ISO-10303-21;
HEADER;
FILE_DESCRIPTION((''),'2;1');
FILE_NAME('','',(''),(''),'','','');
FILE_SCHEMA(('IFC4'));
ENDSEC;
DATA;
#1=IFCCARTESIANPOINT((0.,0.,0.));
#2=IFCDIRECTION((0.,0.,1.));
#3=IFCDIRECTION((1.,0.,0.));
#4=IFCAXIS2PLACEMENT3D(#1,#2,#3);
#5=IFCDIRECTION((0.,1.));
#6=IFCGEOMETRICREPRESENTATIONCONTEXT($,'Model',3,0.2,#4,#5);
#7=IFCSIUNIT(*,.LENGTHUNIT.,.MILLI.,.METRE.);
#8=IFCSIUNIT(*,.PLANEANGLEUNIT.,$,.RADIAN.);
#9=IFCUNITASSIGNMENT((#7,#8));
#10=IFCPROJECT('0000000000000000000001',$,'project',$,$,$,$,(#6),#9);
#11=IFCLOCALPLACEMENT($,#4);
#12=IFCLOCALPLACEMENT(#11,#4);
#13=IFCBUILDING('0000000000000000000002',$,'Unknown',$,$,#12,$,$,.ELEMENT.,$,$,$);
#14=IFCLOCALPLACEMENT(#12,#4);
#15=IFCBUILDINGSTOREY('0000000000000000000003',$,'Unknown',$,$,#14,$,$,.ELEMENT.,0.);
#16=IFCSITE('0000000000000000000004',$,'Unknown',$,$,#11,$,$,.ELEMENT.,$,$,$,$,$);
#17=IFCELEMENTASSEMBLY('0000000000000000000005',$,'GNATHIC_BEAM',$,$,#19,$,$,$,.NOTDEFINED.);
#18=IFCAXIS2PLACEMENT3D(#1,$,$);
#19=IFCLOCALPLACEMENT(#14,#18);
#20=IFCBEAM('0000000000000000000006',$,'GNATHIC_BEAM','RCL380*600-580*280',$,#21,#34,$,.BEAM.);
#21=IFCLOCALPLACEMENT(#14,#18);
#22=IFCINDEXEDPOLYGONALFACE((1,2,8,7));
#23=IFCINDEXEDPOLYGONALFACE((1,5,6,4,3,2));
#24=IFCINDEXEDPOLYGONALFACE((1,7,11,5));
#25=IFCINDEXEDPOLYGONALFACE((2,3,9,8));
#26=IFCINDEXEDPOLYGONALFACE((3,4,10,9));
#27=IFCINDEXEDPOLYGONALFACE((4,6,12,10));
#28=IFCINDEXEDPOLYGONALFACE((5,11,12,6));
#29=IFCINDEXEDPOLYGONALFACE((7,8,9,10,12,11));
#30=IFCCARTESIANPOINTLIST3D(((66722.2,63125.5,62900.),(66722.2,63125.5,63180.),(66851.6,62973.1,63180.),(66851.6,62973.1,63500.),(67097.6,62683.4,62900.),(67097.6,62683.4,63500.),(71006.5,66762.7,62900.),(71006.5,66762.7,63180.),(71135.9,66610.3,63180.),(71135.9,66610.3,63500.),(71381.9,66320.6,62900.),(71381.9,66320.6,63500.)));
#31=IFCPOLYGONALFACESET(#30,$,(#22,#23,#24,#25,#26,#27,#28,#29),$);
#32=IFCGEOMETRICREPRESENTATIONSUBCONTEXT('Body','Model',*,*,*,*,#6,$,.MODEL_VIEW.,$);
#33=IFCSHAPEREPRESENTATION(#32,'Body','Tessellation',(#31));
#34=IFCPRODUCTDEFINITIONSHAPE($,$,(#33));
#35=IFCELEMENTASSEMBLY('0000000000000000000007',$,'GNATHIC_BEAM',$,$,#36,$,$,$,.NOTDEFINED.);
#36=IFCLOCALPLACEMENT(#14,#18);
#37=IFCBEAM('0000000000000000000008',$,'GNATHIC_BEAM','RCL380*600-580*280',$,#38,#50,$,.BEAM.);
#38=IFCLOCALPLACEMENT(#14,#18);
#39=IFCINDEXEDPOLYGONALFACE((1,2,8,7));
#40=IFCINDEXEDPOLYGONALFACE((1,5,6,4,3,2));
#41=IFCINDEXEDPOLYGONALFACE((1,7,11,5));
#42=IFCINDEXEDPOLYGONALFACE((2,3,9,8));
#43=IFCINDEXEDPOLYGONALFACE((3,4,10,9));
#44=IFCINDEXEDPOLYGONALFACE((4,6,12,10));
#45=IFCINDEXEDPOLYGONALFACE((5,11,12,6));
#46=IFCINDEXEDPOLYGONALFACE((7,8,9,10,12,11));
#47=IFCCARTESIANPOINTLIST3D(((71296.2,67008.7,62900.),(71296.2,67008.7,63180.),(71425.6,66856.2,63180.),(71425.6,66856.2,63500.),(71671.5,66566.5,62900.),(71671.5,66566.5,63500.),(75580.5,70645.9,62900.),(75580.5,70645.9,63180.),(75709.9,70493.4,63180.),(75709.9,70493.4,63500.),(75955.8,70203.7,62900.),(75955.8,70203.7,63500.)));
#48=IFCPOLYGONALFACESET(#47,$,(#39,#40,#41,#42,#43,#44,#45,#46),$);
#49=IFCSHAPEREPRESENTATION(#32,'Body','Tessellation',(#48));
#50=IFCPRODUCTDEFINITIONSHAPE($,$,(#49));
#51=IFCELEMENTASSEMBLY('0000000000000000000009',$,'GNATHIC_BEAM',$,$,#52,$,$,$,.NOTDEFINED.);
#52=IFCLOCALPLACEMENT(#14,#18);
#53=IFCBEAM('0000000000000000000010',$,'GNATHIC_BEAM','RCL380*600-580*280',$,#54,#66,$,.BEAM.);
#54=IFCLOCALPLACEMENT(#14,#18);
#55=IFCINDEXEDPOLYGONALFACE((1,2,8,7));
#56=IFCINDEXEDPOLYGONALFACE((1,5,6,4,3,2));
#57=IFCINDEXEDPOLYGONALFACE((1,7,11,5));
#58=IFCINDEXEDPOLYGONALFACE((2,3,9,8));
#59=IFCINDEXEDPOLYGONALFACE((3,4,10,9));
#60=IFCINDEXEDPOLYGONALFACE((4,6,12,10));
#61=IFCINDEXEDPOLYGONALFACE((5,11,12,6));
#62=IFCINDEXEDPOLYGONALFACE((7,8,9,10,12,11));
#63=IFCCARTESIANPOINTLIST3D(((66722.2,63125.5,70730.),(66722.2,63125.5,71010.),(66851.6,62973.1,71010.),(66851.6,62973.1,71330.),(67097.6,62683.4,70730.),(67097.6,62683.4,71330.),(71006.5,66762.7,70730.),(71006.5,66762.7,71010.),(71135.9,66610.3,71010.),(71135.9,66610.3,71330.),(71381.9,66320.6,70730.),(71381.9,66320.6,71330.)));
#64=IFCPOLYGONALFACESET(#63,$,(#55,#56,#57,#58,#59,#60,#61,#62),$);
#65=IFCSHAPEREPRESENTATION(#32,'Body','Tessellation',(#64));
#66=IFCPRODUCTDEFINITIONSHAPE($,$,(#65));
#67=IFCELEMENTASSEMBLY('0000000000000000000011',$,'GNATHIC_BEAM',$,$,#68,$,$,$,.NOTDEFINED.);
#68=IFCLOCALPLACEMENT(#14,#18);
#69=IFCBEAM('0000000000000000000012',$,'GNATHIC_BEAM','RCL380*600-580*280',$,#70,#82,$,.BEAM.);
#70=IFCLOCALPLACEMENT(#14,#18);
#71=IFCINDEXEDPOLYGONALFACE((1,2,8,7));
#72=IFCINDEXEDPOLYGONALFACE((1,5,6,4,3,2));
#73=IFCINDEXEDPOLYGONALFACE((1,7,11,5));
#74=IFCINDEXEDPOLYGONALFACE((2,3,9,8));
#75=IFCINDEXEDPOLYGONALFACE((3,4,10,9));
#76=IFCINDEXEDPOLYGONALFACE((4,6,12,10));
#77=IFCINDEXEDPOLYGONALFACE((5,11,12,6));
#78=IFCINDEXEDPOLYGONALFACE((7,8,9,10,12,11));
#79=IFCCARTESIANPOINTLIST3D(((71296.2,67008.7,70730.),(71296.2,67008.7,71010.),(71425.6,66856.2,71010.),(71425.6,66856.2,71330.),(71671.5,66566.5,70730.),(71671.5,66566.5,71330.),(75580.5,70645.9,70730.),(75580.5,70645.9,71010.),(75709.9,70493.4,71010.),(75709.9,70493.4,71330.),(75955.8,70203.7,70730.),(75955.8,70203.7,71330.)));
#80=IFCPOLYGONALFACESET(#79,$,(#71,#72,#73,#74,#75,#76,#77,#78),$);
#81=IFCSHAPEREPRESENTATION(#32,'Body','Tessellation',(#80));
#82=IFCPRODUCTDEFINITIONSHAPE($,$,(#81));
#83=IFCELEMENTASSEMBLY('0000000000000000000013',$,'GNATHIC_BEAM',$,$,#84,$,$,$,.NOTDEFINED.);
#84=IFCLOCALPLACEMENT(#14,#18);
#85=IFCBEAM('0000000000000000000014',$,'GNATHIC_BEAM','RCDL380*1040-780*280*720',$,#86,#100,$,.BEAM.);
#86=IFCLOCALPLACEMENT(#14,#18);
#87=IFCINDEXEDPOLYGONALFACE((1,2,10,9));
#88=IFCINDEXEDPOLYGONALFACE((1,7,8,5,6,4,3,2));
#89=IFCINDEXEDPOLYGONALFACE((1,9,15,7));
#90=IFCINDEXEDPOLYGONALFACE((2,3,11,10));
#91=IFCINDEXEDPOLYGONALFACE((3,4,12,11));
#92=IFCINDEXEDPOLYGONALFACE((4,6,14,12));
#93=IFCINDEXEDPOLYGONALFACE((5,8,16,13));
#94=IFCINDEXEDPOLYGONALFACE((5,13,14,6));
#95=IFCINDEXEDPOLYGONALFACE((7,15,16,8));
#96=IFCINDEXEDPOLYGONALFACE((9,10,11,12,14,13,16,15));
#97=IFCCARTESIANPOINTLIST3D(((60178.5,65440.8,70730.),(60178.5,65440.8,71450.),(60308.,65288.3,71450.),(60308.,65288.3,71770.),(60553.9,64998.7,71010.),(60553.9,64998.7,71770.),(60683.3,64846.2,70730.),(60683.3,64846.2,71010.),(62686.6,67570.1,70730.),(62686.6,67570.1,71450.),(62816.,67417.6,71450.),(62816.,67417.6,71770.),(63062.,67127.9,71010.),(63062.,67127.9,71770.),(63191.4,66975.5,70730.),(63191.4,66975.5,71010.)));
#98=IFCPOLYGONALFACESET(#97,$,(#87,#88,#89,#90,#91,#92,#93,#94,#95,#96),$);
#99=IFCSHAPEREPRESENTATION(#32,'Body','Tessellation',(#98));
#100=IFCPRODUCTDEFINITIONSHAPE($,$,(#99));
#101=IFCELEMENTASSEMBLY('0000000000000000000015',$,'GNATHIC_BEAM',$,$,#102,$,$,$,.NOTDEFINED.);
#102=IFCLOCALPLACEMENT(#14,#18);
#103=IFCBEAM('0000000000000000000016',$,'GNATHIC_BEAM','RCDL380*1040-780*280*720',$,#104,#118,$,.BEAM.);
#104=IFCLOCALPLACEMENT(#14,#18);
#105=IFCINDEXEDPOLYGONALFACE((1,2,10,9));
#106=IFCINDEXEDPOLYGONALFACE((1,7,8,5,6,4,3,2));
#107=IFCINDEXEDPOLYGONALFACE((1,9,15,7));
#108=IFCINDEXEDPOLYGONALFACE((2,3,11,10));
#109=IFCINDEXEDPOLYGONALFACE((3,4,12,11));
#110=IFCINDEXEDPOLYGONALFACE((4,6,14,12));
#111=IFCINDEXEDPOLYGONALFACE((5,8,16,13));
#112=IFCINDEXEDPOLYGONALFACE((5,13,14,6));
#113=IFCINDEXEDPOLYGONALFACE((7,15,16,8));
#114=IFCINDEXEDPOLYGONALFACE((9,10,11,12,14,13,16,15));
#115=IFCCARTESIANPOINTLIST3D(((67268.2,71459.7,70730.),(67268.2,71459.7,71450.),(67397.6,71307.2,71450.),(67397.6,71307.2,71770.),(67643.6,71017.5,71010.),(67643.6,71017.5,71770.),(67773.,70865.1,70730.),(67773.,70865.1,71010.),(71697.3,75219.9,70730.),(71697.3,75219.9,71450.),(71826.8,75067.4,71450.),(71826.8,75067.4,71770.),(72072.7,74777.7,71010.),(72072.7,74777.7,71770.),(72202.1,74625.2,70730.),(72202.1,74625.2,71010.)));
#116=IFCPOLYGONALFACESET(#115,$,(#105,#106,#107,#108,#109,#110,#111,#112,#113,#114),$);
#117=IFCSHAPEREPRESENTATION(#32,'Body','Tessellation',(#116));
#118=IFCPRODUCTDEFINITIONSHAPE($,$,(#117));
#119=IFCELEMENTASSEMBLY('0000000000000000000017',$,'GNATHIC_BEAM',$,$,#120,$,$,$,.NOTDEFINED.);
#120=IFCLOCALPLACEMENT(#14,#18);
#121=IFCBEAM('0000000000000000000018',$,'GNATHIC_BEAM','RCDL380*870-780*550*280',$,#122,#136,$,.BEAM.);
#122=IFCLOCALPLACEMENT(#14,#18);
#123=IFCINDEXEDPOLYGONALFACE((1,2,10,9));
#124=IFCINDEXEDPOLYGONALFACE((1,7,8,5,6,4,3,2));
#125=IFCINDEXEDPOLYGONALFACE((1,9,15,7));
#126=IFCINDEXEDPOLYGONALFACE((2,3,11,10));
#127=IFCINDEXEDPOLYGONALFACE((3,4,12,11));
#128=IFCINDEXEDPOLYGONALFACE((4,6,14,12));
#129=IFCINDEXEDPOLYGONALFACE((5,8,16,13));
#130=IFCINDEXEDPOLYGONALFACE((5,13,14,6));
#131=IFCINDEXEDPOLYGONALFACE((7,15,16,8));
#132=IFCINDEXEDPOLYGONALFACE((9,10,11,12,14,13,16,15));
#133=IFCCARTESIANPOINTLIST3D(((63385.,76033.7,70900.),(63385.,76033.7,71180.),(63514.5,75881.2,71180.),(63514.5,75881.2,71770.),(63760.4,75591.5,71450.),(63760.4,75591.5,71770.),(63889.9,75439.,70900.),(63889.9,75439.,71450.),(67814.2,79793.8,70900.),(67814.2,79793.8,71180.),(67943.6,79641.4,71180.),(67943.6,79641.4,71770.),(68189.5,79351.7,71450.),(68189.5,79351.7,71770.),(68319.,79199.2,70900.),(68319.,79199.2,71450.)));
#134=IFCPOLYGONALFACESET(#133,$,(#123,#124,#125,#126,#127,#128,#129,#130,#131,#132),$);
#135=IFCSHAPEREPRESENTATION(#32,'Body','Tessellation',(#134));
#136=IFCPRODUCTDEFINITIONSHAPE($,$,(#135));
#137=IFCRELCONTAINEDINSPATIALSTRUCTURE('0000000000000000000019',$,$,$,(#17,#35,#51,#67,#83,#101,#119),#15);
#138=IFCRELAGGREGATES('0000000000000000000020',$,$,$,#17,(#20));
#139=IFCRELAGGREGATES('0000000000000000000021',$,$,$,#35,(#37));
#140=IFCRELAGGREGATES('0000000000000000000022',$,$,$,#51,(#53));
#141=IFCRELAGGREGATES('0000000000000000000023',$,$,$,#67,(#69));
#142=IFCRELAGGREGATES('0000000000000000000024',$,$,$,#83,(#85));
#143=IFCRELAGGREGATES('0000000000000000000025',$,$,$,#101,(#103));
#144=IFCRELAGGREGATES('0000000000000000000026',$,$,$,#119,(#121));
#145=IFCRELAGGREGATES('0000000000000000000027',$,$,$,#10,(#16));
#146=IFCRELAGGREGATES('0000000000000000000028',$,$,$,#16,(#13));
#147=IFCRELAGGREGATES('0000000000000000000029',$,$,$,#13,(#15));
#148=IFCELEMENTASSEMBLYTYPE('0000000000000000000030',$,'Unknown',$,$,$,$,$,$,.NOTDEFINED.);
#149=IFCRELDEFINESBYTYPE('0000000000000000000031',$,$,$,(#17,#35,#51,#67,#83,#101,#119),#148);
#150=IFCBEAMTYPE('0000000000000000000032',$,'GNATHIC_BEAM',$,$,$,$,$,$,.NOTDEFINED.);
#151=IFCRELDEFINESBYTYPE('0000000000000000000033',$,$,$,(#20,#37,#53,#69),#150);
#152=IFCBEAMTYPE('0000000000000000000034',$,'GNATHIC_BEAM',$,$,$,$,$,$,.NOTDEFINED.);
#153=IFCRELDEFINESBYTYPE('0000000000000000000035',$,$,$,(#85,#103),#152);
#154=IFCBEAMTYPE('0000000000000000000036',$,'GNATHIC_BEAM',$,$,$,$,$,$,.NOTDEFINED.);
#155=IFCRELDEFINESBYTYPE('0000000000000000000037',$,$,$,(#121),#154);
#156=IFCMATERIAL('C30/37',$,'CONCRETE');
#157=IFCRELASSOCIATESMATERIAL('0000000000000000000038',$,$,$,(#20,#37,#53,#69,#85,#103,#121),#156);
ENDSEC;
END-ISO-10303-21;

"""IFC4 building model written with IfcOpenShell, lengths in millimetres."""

from ifc_helpers import new_model, si_unit, direction, frame, origin_with_axes, place, context, subcontext, project, spatial, polyline, outline, extrude, material, material_profile, profile_set, profile_usage, type_object, element, aggregate, save


model = new_model("IFC4")

# Units and contexts
model_context = context("Model", 3, precision=0.2, world=origin_with_axes(), true_north=direction((0.0, 1.0)))
body_context = subcontext(model_context, "Body", "Model", "MODEL_VIEW")
ifc_project = project(units=[si_unit("LENGTHUNIT", "METRE", prefix="MILLI"), si_unit("PLANEANGLEUNIT", "RADIAN")], contexts=[model_context])

# Site, building, storey
site_placement = place(None, origin_with_axes())
site = spatial("IfcSite", under=ifc_project, at=site_placement, Name="Unknown", CompositionType="ELEMENT")
building_placement = place(site_placement, origin_with_axes())
building = spatial("IfcBuilding", under=site, at=building_placement, Name="Unknown", CompositionType="ELEMENT")
storey_placement = place(building_placement, origin_with_axes())
storey = spatial("IfcBuildingStorey", under=building, at=storey_placement, Name="Unknown", CompositionType="ELEMENT", Elevation=0.0)

# Shared definitions
element_assembly_type = type_object("IfcElementAssemblyType", Name="Unknown", PredefinedType="NOTDEFINED")

# Element assemblies, beams
ifc_material_1 = material(Name="C30/37", Category="CONCRETE")
ifc_material_profile_1 = material_profile(ifc_material_1, outline(polyline([(-190.0, -300.0), (390.0, -300.0), (390.0, -20.0), (190.0, -20.0), (190.0, 300.0), (-190.0, 300.0), (-190.0, -300.0)])), Name="RCL380*600-580*280")
ifc_profile_set_1 = profile_set([ifc_material_profile_1])
ifc_profile_usage_1 = profile_usage(ifc_profile_set_1, cardinal=2)
beam_type_1 = type_object("IfcBeamType", Name="GNATHIC_BEAM")
assembly_1_placement = place(storey_placement, frame((71258.9, 66465.4, 63200.0), z_axis=(-0.64719, 0.762329, 0.0), x_axis=(-0.762329, -0.64719, 0.0)))
assembly_1 = element("IfcElementAssembly", 1, at=assembly_1_placement, inside=storey, type_object=element_assembly_type, Name="GNATHIC_BEAM", PredefinedType="NOTDEFINED")
beam_1_placement = place(assembly_1_placement, origin_with_axes())
beam_1 = element("IfcBeam", 2, at=beam_1_placement, type_object=beam_type_1, material=ifc_profile_usage_1, Name="GNATHIC_BEAM", Description="RCL380*600-580*280", PredefinedType="BEAM", context=body_context, shape_type="SolidModel", body=[
    extrude(outline(polyline([(-190.0, -300.0), (390.0, -300.0), (390.0, -20.0), (190.0, -20.0), (190.0, 300.0), (-190.0, 300.0), (-190.0, -300.0)])), frame((0.0, 0.0, 0.0), z_axis=(-1.0, 0.0, 0.0), x_axis=(0.0, 0.0, 1.0)), (0.0, 0.0, -1.0), 5620.0),
])
aggregate(assembly_1, [beam_1])
assembly_2_placement = place(storey_placement, frame((75832.9, 70348.6, 63200.0), z_axis=(-0.64719, 0.762329, 0.0), x_axis=(-0.762329, -0.64719, 0.0)))
assembly_2 = element("IfcElementAssembly", 3, at=assembly_2_placement, inside=storey, type_object=element_assembly_type, Name="GNATHIC_BEAM", PredefinedType="NOTDEFINED")
beam_2_placement = place(assembly_2_placement, origin_with_axes())
beam_2 = element("IfcBeam", 4, at=beam_2_placement, type_object=beam_type_1, material=ifc_profile_usage_1, Name="GNATHIC_BEAM", Description="RCL380*600-580*280", PredefinedType="BEAM", context=body_context, shape_type="SolidModel", body=[
    extrude(outline(polyline([(-190.0, -300.0), (390.0, -300.0), (390.0, -20.0), (190.0, -20.0), (190.0, 300.0), (-190.0, 300.0), (-190.0, -300.0)])), frame((0.0, 0.0, 0.0), z_axis=(-1.0, 0.0, 0.0), x_axis=(0.0, 0.0, 1.0)), (0.0, 0.0, -1.0), 5620.0),
])
aggregate(assembly_2, [beam_2])
assembly_3_placement = place(storey_placement, frame((71258.9, 66465.4, 71030.0), z_axis=(-0.64719, 0.762329, 0.0), x_axis=(-0.762329, -0.64719, 0.0)))
assembly_3 = element("IfcElementAssembly", 5, at=assembly_3_placement, inside=storey, type_object=element_assembly_type, Name="GNATHIC_BEAM", PredefinedType="NOTDEFINED")
beam_3_placement = place(assembly_3_placement, origin_with_axes())
beam_3 = element("IfcBeam", 6, at=beam_3_placement, type_object=beam_type_1, material=ifc_profile_usage_1, Name="GNATHIC_BEAM", Description="RCL380*600-580*280", PredefinedType="BEAM", context=body_context, shape_type="SolidModel", body=[
    extrude(outline(polyline([(-190.0, -300.0), (390.0, -300.0), (390.0, -20.0), (190.0, -20.0), (190.0, 300.0), (-190.0, 300.0), (-190.0, -300.0)])), frame((0.0, 0.0, 0.0), z_axis=(-1.0, 0.0, 0.0), x_axis=(0.0, 0.0, 1.0)), (0.0, 0.0, -1.0), 5620.0),
])
aggregate(assembly_3, [beam_3])
assembly_4_placement = place(storey_placement, frame((75832.9, 70348.6, 71030.0), z_axis=(-0.64719, 0.762329, 0.0), x_axis=(-0.762329, -0.64719, 0.0)))
assembly_4 = element("IfcElementAssembly", 7, at=assembly_4_placement, inside=storey, type_object=element_assembly_type, Name="GNATHIC_BEAM", PredefinedType="NOTDEFINED")
beam_4_placement = place(assembly_4_placement, origin_with_axes())
beam_4 = element("IfcBeam", 8, at=beam_4_placement, type_object=beam_type_1, material=ifc_profile_usage_1, Name="GNATHIC_BEAM", Description="RCL380*600-580*280", PredefinedType="BEAM", context=body_context, shape_type="SolidModel", body=[
    extrude(outline(polyline([(-190.0, -300.0), (390.0, -300.0), (390.0, -20.0), (190.0, -20.0), (190.0, 300.0), (-190.0, 300.0), (-190.0, -300.0)])), frame((0.0, 0.0, 0.0), z_axis=(-1.0, 0.0, 0.0), x_axis=(0.0, 0.0, 1.0)), (0.0, 0.0, -1.0), 5620.0),
])
aggregate(assembly_4, [beam_4])
assembly_5_placement = place(storey_placement, frame((60430.9, 65143.5, 71250.0), z_axis=(0.64719, -0.762329, 0.0), x_axis=(0.762329, 0.64719, 0.0)))
assembly_5 = element("IfcElementAssembly", 9, at=assembly_5_placement, inside=storey, type_object=element_assembly_type, Name="GNATHIC_BEAM", PredefinedType="NOTDEFINED")
ifc_material_profile_2 = material_profile(ifc_material_1, outline(polyline([(-390.0, -520.0), (390.0, -520.0), (390.0, -240.0), (190.0, -240.0), (190.0, 520.0), (-190.0, 520.0), (-190.0, 200.0), (-390.0, 200.0), (-390.0, -520.0)])), Name="RCDL380*1040-780*280*720")
ifc_profile_set_2 = profile_set([ifc_material_profile_2])
ifc_profile_usage_2 = profile_usage(ifc_profile_set_2, cardinal=2)
beam_type_2 = type_object("IfcBeamType", Name="GNATHIC_BEAM")
beam_5_placement = place(assembly_5_placement, origin_with_axes())
beam_5 = element("IfcBeam", 10, at=beam_5_placement, type_object=beam_type_2, material=ifc_profile_usage_2, Name="GNATHIC_BEAM", Description="RCDL380*1040-780*280*720", PredefinedType="BEAM", context=body_context, shape_type="SolidModel", body=[
    extrude(outline(polyline([(-390.0, -520.0), (390.0, -520.0), (390.0, -240.0), (190.0, -240.0), (190.0, 520.0), (-190.0, 520.0), (-190.0, 200.0), (-390.0, 200.0), (-390.0, -520.0)])), frame((0.0, 0.0, 0.0), z_axis=(-1.0, 0.0, 0.0), x_axis=(0.0, 0.0, 1.0)), (0.0, 0.0, -1.0), 3290.0),
])
aggregate(assembly_5, [beam_5])
assembly_6_placement = place(storey_placement, frame((67520.6, 71162.4, 71250.0), z_axis=(0.64719, -0.762329, 0.0), x_axis=(0.762329, 0.64719, 0.0)))
assembly_6 = element("IfcElementAssembly", 11, at=assembly_6_placement, inside=storey, type_object=element_assembly_type, Name="GNATHIC_BEAM", PredefinedType="NOTDEFINED")
beam_6_placement = place(assembly_6_placement, origin_with_axes())
beam_6 = element("IfcBeam", 12, at=beam_6_placement, type_object=beam_type_2, material=ifc_profile_usage_2, Name="GNATHIC_BEAM", Description="RCDL380*1040-780*280*720", PredefinedType="BEAM", context=body_context, shape_type="SolidModel", body=[
    extrude(outline(polyline([(-390.0, -520.0), (390.0, -520.0), (390.0, -240.0), (190.0, -240.0), (190.0, 520.0), (-190.0, 520.0), (-190.0, 200.0), (-390.0, 200.0), (-390.0, -520.0)])), frame((0.0, 0.0, 0.0), z_axis=(-1.0, 0.0, 0.0), x_axis=(0.0, 0.0, 1.0)), (0.0, 0.0, -1.0), 5810.0),
])
aggregate(assembly_6, [beam_6])
assembly_7_placement = place(storey_placement, frame((63637.4, 75736.3, 71335.0), z_axis=(0.64719, -0.762329, 0.0), x_axis=(0.762329, 0.64719, 0.0)))
assembly_7 = element("IfcElementAssembly", 13, at=assembly_7_placement, inside=storey, type_object=element_assembly_type, Name="GNATHIC_BEAM", PredefinedType="NOTDEFINED")
ifc_material_profile_3 = material_profile(ifc_material_1, outline(polyline([(-390.0, -435.0), (390.0, -435.0), (390.0, 115.0), (190.0, 115.0), (190.0, 435.0), (-190.0, 435.0), (-190.0, -155.0), (-390.0, -155.0), (-390.0, -435.0)])), Name="RCDL380*870-780*550*280")
ifc_profile_set_3 = profile_set([ifc_material_profile_3])
ifc_profile_usage_3 = profile_usage(ifc_profile_set_3, cardinal=2)
beam_type_3 = type_object("IfcBeamType", Name="GNATHIC_BEAM")
beam_7_placement = place(assembly_7_placement, origin_with_axes())
beam_7 = element("IfcBeam", 14, at=beam_7_placement, type_object=beam_type_3, material=ifc_profile_usage_3, Name="GNATHIC_BEAM", Description="RCDL380*870-780*550*280", PredefinedType="BEAM", context=body_context, shape_type="SolidModel", body=[
    extrude(outline(polyline([(-390.0, -435.0), (390.0, -435.0), (390.0, 115.0), (190.0, 115.0), (190.0, 435.0), (-190.0, 435.0), (-190.0, -155.0), (-390.0, -155.0), (-390.0, -435.0)])), frame((0.0, 0.0, 0.0), z_axis=(-1.0, 0.0, 0.0), x_axis=(0.0, 0.0, 1.0)), (0.0, 0.0, -1.0), 5810.0),
])
aggregate(assembly_7, [beam_7])

save(model, "model.ifc")
